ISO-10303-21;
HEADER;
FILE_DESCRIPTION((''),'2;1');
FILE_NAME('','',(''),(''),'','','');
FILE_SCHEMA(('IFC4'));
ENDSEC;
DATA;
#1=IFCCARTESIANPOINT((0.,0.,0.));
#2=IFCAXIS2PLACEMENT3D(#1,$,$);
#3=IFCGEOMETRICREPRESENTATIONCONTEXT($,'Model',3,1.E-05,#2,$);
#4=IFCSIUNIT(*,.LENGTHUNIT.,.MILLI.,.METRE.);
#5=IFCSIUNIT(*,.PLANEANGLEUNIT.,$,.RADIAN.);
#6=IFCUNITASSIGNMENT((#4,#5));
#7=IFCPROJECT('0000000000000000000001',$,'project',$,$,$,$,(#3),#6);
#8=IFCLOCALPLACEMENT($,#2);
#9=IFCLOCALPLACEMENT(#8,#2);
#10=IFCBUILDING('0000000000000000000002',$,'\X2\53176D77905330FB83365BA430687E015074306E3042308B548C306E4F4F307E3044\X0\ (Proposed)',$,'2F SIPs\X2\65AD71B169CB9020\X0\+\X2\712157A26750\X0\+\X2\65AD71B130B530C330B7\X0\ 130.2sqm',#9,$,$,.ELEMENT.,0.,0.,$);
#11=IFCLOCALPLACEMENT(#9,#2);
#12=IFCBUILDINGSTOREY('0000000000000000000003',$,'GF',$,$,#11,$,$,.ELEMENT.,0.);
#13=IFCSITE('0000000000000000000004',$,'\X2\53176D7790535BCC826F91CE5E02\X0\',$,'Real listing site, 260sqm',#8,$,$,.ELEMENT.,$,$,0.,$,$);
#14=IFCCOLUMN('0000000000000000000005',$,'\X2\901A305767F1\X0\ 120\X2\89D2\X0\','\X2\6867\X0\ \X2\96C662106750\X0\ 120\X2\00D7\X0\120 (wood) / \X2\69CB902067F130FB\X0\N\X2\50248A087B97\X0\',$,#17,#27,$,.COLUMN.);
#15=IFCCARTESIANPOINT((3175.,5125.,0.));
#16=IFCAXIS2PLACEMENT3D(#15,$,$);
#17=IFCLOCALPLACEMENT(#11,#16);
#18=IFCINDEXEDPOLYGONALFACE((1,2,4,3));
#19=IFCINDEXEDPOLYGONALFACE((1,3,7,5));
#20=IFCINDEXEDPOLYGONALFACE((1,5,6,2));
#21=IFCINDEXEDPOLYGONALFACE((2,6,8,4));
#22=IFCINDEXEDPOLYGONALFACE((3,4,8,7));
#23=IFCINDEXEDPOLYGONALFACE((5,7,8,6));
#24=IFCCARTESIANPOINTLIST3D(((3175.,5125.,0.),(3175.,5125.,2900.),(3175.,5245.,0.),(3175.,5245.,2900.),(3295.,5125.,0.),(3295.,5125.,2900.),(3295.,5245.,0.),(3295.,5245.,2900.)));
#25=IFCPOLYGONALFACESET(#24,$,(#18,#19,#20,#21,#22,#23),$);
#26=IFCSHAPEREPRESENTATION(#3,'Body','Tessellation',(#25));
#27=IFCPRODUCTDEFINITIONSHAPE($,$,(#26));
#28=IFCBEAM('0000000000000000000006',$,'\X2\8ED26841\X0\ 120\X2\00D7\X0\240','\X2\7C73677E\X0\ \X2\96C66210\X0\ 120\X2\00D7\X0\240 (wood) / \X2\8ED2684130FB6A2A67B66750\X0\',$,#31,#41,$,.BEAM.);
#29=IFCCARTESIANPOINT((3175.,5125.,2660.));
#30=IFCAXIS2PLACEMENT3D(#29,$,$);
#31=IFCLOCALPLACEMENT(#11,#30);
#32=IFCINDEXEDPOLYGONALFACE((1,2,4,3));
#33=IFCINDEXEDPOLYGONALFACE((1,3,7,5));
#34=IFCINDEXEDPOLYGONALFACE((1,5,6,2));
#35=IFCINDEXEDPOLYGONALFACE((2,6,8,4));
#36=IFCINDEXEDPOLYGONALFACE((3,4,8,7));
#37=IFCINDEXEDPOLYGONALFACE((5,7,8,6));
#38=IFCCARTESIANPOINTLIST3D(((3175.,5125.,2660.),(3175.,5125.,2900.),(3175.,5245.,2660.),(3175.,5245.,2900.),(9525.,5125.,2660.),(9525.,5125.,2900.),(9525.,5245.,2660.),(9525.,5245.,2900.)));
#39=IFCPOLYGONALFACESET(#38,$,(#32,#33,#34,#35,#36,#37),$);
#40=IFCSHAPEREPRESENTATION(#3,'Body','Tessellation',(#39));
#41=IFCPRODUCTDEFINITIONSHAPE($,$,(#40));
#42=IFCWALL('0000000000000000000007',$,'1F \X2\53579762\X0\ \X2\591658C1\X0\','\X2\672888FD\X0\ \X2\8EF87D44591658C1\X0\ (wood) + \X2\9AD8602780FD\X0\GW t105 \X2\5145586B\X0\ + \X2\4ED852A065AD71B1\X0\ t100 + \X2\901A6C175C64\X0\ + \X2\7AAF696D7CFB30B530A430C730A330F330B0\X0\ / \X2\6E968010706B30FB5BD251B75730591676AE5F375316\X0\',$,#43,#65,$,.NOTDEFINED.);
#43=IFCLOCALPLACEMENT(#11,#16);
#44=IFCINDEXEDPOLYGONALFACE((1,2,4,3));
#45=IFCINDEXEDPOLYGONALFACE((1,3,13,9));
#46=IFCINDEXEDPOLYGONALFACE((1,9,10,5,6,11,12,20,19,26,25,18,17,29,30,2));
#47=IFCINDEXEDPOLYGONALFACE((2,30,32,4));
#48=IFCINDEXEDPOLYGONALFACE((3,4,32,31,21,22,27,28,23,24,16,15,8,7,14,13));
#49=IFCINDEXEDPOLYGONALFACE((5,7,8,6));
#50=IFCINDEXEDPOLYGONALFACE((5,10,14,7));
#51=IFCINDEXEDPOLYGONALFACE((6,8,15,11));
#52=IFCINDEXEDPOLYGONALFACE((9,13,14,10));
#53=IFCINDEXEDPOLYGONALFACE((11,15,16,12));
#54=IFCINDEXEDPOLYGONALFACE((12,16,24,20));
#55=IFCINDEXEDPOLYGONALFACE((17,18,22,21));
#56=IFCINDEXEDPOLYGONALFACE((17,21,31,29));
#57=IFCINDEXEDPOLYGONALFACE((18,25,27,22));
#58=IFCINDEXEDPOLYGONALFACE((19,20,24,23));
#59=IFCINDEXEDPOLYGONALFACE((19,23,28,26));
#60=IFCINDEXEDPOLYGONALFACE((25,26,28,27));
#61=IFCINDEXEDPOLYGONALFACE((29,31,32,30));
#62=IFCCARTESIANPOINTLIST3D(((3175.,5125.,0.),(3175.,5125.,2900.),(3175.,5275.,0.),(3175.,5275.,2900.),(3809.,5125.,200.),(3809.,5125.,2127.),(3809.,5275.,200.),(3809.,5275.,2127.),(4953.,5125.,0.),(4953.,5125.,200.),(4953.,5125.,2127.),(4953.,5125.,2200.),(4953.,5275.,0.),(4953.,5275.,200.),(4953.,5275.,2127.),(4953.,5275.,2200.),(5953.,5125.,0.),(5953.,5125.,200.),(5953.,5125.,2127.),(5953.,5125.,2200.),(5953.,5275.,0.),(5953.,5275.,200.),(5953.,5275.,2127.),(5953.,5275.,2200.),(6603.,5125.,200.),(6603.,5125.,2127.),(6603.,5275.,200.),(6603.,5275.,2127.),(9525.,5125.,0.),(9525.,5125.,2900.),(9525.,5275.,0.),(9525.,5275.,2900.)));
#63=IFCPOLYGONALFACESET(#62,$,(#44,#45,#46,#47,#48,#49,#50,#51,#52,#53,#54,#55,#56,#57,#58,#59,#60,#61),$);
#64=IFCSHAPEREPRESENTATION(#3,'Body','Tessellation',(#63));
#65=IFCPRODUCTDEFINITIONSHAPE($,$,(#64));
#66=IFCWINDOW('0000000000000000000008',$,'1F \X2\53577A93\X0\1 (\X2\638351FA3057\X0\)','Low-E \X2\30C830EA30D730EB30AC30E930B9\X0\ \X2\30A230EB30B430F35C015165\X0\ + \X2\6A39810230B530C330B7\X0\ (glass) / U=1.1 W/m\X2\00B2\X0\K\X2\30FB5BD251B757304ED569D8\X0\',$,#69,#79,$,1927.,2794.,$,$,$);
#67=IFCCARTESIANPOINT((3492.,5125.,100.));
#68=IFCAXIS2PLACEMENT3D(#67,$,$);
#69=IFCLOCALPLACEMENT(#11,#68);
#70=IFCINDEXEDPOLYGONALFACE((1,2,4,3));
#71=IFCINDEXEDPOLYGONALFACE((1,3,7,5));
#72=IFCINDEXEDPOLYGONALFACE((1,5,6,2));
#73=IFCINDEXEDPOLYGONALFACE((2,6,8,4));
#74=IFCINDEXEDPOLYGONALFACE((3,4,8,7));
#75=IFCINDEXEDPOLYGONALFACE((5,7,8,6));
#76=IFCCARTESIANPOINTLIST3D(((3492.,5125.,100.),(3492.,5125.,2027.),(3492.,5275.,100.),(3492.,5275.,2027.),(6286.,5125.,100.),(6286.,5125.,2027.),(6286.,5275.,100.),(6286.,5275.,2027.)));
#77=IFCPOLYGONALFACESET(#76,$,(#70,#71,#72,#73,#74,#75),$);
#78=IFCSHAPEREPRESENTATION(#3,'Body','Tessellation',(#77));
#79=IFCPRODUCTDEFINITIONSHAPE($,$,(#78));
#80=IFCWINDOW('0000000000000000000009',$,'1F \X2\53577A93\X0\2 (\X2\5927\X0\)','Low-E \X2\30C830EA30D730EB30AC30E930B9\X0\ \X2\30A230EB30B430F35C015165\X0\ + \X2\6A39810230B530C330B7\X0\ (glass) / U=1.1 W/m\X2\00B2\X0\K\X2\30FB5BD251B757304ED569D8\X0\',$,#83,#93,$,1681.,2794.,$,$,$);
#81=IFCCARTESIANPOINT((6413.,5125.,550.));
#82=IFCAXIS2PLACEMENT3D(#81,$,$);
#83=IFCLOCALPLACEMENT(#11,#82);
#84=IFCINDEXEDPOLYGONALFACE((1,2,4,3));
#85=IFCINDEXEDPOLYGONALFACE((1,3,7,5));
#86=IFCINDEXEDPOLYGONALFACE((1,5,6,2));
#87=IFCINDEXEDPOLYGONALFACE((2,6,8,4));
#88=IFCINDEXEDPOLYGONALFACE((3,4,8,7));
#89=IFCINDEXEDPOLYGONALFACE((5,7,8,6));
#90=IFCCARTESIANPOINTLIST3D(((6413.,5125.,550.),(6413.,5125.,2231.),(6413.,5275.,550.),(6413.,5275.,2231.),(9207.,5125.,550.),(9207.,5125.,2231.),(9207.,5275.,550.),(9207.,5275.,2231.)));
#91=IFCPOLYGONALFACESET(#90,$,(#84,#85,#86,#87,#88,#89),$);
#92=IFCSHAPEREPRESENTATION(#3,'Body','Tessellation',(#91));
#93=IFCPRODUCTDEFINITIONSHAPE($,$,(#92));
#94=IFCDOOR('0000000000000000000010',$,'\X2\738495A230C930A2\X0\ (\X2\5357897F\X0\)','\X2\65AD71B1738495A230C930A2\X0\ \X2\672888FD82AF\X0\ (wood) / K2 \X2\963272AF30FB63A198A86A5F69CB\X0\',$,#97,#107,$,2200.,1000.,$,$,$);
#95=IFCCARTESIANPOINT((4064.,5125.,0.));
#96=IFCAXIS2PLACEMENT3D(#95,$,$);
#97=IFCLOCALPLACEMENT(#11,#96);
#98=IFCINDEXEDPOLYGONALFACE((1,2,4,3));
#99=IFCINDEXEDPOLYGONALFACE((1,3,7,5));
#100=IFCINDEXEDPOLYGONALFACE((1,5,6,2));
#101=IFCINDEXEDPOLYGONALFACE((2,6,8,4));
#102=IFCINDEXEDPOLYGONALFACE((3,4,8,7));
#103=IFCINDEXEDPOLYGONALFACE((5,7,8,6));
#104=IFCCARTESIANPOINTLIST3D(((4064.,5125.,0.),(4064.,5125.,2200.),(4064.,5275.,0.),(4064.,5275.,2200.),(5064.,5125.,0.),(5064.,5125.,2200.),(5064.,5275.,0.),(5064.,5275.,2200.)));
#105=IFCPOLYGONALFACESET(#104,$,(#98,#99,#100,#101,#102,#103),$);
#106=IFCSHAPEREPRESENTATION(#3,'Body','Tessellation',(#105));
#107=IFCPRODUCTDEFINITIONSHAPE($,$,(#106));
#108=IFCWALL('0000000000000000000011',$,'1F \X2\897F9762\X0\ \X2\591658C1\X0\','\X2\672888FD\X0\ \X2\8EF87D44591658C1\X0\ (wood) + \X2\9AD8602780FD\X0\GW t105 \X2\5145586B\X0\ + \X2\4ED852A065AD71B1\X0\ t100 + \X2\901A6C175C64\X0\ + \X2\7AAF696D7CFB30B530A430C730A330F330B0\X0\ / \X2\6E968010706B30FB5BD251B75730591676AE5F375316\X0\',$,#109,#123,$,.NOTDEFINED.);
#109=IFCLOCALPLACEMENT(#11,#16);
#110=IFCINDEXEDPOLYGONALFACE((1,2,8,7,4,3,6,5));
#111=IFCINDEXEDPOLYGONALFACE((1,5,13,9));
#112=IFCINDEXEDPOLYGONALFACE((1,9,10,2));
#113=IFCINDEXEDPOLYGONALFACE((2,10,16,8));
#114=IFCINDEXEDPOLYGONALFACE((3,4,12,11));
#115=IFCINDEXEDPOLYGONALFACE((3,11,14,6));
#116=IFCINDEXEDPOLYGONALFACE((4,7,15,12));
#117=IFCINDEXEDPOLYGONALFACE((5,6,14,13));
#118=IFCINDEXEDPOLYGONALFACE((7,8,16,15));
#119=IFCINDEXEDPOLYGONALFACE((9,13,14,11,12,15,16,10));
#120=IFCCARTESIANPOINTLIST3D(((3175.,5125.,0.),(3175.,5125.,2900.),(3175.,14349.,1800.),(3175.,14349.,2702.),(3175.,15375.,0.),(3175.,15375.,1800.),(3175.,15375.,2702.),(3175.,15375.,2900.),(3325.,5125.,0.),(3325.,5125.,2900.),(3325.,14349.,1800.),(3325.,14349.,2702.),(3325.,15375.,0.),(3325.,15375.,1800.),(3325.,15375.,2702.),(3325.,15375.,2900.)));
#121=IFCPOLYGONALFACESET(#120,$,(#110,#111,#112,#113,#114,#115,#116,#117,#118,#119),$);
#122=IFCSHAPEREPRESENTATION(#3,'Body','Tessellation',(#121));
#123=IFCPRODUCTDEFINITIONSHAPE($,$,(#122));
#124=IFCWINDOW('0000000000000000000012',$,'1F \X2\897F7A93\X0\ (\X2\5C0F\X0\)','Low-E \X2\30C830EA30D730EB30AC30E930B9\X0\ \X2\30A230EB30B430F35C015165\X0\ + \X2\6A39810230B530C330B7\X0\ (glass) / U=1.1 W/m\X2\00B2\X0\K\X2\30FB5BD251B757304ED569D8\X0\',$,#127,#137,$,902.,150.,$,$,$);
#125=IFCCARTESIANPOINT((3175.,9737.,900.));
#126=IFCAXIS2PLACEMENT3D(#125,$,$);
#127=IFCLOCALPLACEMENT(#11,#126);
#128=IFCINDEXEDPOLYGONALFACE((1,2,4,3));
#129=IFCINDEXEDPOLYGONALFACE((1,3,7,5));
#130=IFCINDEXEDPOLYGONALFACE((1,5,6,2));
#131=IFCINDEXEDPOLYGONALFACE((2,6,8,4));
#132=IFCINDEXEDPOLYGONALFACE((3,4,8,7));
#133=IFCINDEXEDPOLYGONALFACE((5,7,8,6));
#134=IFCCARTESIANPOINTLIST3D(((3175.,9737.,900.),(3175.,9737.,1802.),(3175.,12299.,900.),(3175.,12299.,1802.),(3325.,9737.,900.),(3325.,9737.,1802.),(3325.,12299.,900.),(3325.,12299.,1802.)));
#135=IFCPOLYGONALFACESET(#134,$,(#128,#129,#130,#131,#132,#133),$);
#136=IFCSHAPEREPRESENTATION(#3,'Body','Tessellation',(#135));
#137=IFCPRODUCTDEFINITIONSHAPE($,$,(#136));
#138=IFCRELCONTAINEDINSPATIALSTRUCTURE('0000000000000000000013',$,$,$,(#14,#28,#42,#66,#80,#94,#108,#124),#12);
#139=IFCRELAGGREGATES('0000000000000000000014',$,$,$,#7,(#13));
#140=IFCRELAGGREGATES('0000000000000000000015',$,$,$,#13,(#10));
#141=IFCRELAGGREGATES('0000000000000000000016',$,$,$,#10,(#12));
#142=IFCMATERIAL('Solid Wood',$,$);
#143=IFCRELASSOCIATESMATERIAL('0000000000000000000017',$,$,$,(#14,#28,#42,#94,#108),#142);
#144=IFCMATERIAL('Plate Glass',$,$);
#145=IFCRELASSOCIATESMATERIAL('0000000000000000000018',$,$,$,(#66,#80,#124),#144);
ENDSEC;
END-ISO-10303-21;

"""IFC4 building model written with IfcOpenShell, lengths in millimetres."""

from ifc_helpers import new_model, si_unit, frame, frame_2d, origin, place, context, project, spatial, rectangle, extrude, material, element, fill, save


model = new_model("IFC4")

# Units and contexts
model_context = context("Model", 3, precision=1e-05, world=origin())
ifc_project = project(units=[si_unit("LENGTHUNIT", "METRE", prefix="MILLI"), si_unit("PLANEANGLEUNIT", "RADIAN")], contexts=[model_context])

# Site, building, storey
site_placement = place(None, origin())
site = spatial("IfcSite", under=ifc_project, at=site_placement, Name="北海道富良野市", ObjectType="Real listing site, 260sqm", CompositionType="ELEMENT", RefElevation=0.0)
building_placement = place(site_placement, origin())
building = spatial("IfcBuilding", under=site, at=building_placement, Name="北海道・茶室と縁側のある和の住まい (Proposed)", ObjectType="2F SIPs断熱構造+無垢材+断熱サッシ 130.2sqm", CompositionType="ELEMENT", ElevationOfRefHeight=0.0, ElevationOfTerrain=0.0)
storey_placement = place(building_placement, origin())
storey = spatial("IfcBuildingStorey", under=building, at=storey_placement, Name="GF", CompositionType="ELEMENT", Elevation=0.0)

# Column
ifc_material_1 = material(Name="Solid Wood")
column_placement = place(storey_placement, frame((3175.0, 5125.0, 0.0)))
element("IfcColumn", 1, at=column_placement, inside=storey, material=ifc_material_1, Name="通し柱 120角", Description="桧 集成材 120×120 (wood) / 構造柱・N値計算", PredefinedType="COLUMN", context=model_context, shape_type="SweptSolid", body=[
    extrude(rectangle(XDim=120.0, YDim=120.0, at=frame_2d((60.0, 60.0))), frame((3175.0, 5125.0, 0.0)), (0.0, 0.0, 1.0), 2900.0),
])

# Beam
beam_1_placement = place(storey_placement, frame((3175.0, 5125.0, 2660.0)))
element("IfcBeam", 2, at=beam_1_placement, inside=storey, material=ifc_material_1, Name="軒桁 120×240", Description="米松 集成 120×240 (wood) / 軒桁・横架材", PredefinedType="BEAM", context=model_context, shape_type="SweptSolid", body=[
    extrude(rectangle(XDim=6350.0, YDim=120.0, at=frame_2d((3175.0, 60.0))), frame((3175.0, 5125.0, 2660.0)), (0.0, 0.0, 1.0), 240.0),
])

# Wall, openings, windows, door
wall_1_placement = place(storey_placement, frame((3175.0, 5125.0, 0.0)))
wall_1 = element("IfcWall", 3, at=wall_1_placement, inside=storey, material=ifc_material_1, Name="1F 南面 外壁", Description="木製 軸組外壁 (wood) + 高性能GW t105 充填 + 付加断熱 t100 + 通気層 + 窯業系サイディング / 準耐火・寒冷地外皮強化", PredefinedType="NOTDEFINED", context=model_context, shape_type="SweptSolid", body=[
    extrude(rectangle(XDim=6350.0, YDim=150.0, at=frame_2d((3175.0, 75.0))), frame((3175.0, 5125.0, 0.0)), (0.0, 0.0, 1.0), 2900.0),
])
opening_1_placement = place(storey_placement, frame((3492.0, 5125.0, 100.0)))
opening_1 = element("IfcOpeningElement", 4, at=opening_1_placement, cuts=wall_1, PredefinedType="NOTDEFINED", context=model_context, shape_type="SweptSolid", body=[
    extrude(rectangle(XDim=2794.0, YDim=150.0, at=frame_2d((1397.0, 75.0))), frame((3492.0, 5125.0, 100.0)), (0.0, 0.0, 1.0), 1927.0),
])
opening_2_placement = place(storey_placement, frame((6413.0, 5125.0, 550.0)))
opening_2 = element("IfcOpeningElement", 5, at=opening_2_placement, cuts=wall_1, PredefinedType="NOTDEFINED", context=model_context, shape_type="SweptSolid", body=[
    extrude(rectangle(XDim=2794.0, YDim=150.0, at=frame_2d((1397.0, 75.0))), frame((6413.0, 5125.0, 550.0)), (0.0, 0.0, 1.0), 1681.0),
])
opening_3_placement = place(storey_placement, frame((4064.0, 5125.0, 0.0)))
opening_3 = element("IfcOpeningElement", 6, at=opening_3_placement, cuts=wall_1, PredefinedType="NOTDEFINED", context=model_context, shape_type="SweptSolid", body=[
    extrude(rectangle(XDim=1000.0, YDim=150.0, at=frame_2d((500.0, 75.0))), frame((4064.0, 5125.0, 0.0)), (0.0, 0.0, 1.0), 2200.0),
])
ifc_material_2 = material(Name="Plate Glass")
window_1_placement = place(storey_placement, frame((3492.0, 5125.0, 100.0)))
window_1 = element("IfcWindow", 7, at=window_1_placement, inside=storey, material=ifc_material_2, Name="1F 南窓1 (掃出し)", Description="Low-E トリプルガラス アルゴン封入 + 樹脂サッシ (glass) / U=1.1 W/m²K・寒冷地仕様", OverallHeight=1927.0, OverallWidth=2794.0, context=model_context, shape_type="SweptSolid", body=[
    extrude(rectangle(XDim=2794.0, YDim=150.0, at=frame_2d((1397.0, 75.0))), frame((3492.0, 5125.0, 100.0)), (0.0, 0.0, 1.0), 1927.0),
])
fill(opening_1, window_1)
window_2_placement = place(storey_placement, frame((6413.0, 5125.0, 550.0)))
window_2 = element("IfcWindow", 8, at=window_2_placement, inside=storey, material=ifc_material_2, Name="1F 南窓2 (大)", Description="Low-E トリプルガラス アルゴン封入 + 樹脂サッシ (glass) / U=1.1 W/m²K・寒冷地仕様", OverallHeight=1681.0, OverallWidth=2794.0, context=model_context, shape_type="SweptSolid", body=[
    extrude(rectangle(XDim=2794.0, YDim=150.0, at=frame_2d((1397.0, 75.0))), frame((6413.0, 5125.0, 550.0)), (0.0, 0.0, 1.0), 1681.0),
])
fill(opening_2, window_2)
door_placement = place(storey_placement, frame((4064.0, 5125.0, 0.0)))
door = element("IfcDoor", 9, at=door_placement, inside=storey, material=ifc_material_1, Name="玄関ドア (南西)", Description="断熱玄関ドア 木製芯 (wood) / K2 防犯・採風機構", OverallHeight=2200.0, OverallWidth=1000.0, context=model_context, shape_type="SweptSolid", body=[
    extrude(rectangle(XDim=1000.0, YDim=150.0, at=frame_2d((500.0, 75.0))), frame((4064.0, 5125.0, 0.0)), (0.0, 0.0, 1.0), 2200.0),
])
fill(opening_3, door)

# Wall, opening, window
wall_2_placement = place(storey_placement, frame((3175.0, 5125.0, 0.0)))
wall_2 = element("IfcWall", 10, at=wall_2_placement, inside=storey, material=ifc_material_1, Name="1F 西面 外壁", Description="木製 軸組外壁 (wood) + 高性能GW t105 充填 + 付加断熱 t100 + 通気層 + 窯業系サイディング / 準耐火・寒冷地外皮強化", PredefinedType="NOTDEFINED", context=model_context, shape_type="SweptSolid", body=[
    extrude(rectangle(XDim=150.0, YDim=10250.0, at=frame_2d((75.0, 5125.0))), frame((3175.0, 5125.0, 0.0)), (0.0, 0.0, 1.0), 2900.0),
])
opening_4_placement = place(storey_placement, frame((3175.0, 9737.0, 900.0)))
opening_4 = element("IfcOpeningElement", 11, at=opening_4_placement, cuts=wall_2, PredefinedType="NOTDEFINED", context=model_context, shape_type="SweptSolid", body=[
    extrude(rectangle(XDim=150.0, YDim=2562.0, at=frame_2d((75.0, 1281.0))), frame((3175.0, 9737.0, 900.0)), (0.0, 0.0, 1.0), 902.0),
])
window_3_placement = place(storey_placement, frame((3175.0, 9737.0, 900.0)))
window_3 = element("IfcWindow", 12, at=window_3_placement, inside=storey, material=ifc_material_2, Name="1F 西窓 (小)", Description="Low-E トリプルガラス アルゴン封入 + 樹脂サッシ (glass) / U=1.1 W/m²K・寒冷地仕様", OverallHeight=902.0, OverallWidth=150.0, context=model_context, shape_type="SweptSolid", body=[
    extrude(rectangle(XDim=150.0, YDim=2562.0, at=frame_2d((75.0, 1281.0))), frame((3175.0, 9737.0, 900.0)), (0.0, 0.0, 1.0), 902.0),
])
fill(opening_4, window_3)

save(model, "model.ifc")
